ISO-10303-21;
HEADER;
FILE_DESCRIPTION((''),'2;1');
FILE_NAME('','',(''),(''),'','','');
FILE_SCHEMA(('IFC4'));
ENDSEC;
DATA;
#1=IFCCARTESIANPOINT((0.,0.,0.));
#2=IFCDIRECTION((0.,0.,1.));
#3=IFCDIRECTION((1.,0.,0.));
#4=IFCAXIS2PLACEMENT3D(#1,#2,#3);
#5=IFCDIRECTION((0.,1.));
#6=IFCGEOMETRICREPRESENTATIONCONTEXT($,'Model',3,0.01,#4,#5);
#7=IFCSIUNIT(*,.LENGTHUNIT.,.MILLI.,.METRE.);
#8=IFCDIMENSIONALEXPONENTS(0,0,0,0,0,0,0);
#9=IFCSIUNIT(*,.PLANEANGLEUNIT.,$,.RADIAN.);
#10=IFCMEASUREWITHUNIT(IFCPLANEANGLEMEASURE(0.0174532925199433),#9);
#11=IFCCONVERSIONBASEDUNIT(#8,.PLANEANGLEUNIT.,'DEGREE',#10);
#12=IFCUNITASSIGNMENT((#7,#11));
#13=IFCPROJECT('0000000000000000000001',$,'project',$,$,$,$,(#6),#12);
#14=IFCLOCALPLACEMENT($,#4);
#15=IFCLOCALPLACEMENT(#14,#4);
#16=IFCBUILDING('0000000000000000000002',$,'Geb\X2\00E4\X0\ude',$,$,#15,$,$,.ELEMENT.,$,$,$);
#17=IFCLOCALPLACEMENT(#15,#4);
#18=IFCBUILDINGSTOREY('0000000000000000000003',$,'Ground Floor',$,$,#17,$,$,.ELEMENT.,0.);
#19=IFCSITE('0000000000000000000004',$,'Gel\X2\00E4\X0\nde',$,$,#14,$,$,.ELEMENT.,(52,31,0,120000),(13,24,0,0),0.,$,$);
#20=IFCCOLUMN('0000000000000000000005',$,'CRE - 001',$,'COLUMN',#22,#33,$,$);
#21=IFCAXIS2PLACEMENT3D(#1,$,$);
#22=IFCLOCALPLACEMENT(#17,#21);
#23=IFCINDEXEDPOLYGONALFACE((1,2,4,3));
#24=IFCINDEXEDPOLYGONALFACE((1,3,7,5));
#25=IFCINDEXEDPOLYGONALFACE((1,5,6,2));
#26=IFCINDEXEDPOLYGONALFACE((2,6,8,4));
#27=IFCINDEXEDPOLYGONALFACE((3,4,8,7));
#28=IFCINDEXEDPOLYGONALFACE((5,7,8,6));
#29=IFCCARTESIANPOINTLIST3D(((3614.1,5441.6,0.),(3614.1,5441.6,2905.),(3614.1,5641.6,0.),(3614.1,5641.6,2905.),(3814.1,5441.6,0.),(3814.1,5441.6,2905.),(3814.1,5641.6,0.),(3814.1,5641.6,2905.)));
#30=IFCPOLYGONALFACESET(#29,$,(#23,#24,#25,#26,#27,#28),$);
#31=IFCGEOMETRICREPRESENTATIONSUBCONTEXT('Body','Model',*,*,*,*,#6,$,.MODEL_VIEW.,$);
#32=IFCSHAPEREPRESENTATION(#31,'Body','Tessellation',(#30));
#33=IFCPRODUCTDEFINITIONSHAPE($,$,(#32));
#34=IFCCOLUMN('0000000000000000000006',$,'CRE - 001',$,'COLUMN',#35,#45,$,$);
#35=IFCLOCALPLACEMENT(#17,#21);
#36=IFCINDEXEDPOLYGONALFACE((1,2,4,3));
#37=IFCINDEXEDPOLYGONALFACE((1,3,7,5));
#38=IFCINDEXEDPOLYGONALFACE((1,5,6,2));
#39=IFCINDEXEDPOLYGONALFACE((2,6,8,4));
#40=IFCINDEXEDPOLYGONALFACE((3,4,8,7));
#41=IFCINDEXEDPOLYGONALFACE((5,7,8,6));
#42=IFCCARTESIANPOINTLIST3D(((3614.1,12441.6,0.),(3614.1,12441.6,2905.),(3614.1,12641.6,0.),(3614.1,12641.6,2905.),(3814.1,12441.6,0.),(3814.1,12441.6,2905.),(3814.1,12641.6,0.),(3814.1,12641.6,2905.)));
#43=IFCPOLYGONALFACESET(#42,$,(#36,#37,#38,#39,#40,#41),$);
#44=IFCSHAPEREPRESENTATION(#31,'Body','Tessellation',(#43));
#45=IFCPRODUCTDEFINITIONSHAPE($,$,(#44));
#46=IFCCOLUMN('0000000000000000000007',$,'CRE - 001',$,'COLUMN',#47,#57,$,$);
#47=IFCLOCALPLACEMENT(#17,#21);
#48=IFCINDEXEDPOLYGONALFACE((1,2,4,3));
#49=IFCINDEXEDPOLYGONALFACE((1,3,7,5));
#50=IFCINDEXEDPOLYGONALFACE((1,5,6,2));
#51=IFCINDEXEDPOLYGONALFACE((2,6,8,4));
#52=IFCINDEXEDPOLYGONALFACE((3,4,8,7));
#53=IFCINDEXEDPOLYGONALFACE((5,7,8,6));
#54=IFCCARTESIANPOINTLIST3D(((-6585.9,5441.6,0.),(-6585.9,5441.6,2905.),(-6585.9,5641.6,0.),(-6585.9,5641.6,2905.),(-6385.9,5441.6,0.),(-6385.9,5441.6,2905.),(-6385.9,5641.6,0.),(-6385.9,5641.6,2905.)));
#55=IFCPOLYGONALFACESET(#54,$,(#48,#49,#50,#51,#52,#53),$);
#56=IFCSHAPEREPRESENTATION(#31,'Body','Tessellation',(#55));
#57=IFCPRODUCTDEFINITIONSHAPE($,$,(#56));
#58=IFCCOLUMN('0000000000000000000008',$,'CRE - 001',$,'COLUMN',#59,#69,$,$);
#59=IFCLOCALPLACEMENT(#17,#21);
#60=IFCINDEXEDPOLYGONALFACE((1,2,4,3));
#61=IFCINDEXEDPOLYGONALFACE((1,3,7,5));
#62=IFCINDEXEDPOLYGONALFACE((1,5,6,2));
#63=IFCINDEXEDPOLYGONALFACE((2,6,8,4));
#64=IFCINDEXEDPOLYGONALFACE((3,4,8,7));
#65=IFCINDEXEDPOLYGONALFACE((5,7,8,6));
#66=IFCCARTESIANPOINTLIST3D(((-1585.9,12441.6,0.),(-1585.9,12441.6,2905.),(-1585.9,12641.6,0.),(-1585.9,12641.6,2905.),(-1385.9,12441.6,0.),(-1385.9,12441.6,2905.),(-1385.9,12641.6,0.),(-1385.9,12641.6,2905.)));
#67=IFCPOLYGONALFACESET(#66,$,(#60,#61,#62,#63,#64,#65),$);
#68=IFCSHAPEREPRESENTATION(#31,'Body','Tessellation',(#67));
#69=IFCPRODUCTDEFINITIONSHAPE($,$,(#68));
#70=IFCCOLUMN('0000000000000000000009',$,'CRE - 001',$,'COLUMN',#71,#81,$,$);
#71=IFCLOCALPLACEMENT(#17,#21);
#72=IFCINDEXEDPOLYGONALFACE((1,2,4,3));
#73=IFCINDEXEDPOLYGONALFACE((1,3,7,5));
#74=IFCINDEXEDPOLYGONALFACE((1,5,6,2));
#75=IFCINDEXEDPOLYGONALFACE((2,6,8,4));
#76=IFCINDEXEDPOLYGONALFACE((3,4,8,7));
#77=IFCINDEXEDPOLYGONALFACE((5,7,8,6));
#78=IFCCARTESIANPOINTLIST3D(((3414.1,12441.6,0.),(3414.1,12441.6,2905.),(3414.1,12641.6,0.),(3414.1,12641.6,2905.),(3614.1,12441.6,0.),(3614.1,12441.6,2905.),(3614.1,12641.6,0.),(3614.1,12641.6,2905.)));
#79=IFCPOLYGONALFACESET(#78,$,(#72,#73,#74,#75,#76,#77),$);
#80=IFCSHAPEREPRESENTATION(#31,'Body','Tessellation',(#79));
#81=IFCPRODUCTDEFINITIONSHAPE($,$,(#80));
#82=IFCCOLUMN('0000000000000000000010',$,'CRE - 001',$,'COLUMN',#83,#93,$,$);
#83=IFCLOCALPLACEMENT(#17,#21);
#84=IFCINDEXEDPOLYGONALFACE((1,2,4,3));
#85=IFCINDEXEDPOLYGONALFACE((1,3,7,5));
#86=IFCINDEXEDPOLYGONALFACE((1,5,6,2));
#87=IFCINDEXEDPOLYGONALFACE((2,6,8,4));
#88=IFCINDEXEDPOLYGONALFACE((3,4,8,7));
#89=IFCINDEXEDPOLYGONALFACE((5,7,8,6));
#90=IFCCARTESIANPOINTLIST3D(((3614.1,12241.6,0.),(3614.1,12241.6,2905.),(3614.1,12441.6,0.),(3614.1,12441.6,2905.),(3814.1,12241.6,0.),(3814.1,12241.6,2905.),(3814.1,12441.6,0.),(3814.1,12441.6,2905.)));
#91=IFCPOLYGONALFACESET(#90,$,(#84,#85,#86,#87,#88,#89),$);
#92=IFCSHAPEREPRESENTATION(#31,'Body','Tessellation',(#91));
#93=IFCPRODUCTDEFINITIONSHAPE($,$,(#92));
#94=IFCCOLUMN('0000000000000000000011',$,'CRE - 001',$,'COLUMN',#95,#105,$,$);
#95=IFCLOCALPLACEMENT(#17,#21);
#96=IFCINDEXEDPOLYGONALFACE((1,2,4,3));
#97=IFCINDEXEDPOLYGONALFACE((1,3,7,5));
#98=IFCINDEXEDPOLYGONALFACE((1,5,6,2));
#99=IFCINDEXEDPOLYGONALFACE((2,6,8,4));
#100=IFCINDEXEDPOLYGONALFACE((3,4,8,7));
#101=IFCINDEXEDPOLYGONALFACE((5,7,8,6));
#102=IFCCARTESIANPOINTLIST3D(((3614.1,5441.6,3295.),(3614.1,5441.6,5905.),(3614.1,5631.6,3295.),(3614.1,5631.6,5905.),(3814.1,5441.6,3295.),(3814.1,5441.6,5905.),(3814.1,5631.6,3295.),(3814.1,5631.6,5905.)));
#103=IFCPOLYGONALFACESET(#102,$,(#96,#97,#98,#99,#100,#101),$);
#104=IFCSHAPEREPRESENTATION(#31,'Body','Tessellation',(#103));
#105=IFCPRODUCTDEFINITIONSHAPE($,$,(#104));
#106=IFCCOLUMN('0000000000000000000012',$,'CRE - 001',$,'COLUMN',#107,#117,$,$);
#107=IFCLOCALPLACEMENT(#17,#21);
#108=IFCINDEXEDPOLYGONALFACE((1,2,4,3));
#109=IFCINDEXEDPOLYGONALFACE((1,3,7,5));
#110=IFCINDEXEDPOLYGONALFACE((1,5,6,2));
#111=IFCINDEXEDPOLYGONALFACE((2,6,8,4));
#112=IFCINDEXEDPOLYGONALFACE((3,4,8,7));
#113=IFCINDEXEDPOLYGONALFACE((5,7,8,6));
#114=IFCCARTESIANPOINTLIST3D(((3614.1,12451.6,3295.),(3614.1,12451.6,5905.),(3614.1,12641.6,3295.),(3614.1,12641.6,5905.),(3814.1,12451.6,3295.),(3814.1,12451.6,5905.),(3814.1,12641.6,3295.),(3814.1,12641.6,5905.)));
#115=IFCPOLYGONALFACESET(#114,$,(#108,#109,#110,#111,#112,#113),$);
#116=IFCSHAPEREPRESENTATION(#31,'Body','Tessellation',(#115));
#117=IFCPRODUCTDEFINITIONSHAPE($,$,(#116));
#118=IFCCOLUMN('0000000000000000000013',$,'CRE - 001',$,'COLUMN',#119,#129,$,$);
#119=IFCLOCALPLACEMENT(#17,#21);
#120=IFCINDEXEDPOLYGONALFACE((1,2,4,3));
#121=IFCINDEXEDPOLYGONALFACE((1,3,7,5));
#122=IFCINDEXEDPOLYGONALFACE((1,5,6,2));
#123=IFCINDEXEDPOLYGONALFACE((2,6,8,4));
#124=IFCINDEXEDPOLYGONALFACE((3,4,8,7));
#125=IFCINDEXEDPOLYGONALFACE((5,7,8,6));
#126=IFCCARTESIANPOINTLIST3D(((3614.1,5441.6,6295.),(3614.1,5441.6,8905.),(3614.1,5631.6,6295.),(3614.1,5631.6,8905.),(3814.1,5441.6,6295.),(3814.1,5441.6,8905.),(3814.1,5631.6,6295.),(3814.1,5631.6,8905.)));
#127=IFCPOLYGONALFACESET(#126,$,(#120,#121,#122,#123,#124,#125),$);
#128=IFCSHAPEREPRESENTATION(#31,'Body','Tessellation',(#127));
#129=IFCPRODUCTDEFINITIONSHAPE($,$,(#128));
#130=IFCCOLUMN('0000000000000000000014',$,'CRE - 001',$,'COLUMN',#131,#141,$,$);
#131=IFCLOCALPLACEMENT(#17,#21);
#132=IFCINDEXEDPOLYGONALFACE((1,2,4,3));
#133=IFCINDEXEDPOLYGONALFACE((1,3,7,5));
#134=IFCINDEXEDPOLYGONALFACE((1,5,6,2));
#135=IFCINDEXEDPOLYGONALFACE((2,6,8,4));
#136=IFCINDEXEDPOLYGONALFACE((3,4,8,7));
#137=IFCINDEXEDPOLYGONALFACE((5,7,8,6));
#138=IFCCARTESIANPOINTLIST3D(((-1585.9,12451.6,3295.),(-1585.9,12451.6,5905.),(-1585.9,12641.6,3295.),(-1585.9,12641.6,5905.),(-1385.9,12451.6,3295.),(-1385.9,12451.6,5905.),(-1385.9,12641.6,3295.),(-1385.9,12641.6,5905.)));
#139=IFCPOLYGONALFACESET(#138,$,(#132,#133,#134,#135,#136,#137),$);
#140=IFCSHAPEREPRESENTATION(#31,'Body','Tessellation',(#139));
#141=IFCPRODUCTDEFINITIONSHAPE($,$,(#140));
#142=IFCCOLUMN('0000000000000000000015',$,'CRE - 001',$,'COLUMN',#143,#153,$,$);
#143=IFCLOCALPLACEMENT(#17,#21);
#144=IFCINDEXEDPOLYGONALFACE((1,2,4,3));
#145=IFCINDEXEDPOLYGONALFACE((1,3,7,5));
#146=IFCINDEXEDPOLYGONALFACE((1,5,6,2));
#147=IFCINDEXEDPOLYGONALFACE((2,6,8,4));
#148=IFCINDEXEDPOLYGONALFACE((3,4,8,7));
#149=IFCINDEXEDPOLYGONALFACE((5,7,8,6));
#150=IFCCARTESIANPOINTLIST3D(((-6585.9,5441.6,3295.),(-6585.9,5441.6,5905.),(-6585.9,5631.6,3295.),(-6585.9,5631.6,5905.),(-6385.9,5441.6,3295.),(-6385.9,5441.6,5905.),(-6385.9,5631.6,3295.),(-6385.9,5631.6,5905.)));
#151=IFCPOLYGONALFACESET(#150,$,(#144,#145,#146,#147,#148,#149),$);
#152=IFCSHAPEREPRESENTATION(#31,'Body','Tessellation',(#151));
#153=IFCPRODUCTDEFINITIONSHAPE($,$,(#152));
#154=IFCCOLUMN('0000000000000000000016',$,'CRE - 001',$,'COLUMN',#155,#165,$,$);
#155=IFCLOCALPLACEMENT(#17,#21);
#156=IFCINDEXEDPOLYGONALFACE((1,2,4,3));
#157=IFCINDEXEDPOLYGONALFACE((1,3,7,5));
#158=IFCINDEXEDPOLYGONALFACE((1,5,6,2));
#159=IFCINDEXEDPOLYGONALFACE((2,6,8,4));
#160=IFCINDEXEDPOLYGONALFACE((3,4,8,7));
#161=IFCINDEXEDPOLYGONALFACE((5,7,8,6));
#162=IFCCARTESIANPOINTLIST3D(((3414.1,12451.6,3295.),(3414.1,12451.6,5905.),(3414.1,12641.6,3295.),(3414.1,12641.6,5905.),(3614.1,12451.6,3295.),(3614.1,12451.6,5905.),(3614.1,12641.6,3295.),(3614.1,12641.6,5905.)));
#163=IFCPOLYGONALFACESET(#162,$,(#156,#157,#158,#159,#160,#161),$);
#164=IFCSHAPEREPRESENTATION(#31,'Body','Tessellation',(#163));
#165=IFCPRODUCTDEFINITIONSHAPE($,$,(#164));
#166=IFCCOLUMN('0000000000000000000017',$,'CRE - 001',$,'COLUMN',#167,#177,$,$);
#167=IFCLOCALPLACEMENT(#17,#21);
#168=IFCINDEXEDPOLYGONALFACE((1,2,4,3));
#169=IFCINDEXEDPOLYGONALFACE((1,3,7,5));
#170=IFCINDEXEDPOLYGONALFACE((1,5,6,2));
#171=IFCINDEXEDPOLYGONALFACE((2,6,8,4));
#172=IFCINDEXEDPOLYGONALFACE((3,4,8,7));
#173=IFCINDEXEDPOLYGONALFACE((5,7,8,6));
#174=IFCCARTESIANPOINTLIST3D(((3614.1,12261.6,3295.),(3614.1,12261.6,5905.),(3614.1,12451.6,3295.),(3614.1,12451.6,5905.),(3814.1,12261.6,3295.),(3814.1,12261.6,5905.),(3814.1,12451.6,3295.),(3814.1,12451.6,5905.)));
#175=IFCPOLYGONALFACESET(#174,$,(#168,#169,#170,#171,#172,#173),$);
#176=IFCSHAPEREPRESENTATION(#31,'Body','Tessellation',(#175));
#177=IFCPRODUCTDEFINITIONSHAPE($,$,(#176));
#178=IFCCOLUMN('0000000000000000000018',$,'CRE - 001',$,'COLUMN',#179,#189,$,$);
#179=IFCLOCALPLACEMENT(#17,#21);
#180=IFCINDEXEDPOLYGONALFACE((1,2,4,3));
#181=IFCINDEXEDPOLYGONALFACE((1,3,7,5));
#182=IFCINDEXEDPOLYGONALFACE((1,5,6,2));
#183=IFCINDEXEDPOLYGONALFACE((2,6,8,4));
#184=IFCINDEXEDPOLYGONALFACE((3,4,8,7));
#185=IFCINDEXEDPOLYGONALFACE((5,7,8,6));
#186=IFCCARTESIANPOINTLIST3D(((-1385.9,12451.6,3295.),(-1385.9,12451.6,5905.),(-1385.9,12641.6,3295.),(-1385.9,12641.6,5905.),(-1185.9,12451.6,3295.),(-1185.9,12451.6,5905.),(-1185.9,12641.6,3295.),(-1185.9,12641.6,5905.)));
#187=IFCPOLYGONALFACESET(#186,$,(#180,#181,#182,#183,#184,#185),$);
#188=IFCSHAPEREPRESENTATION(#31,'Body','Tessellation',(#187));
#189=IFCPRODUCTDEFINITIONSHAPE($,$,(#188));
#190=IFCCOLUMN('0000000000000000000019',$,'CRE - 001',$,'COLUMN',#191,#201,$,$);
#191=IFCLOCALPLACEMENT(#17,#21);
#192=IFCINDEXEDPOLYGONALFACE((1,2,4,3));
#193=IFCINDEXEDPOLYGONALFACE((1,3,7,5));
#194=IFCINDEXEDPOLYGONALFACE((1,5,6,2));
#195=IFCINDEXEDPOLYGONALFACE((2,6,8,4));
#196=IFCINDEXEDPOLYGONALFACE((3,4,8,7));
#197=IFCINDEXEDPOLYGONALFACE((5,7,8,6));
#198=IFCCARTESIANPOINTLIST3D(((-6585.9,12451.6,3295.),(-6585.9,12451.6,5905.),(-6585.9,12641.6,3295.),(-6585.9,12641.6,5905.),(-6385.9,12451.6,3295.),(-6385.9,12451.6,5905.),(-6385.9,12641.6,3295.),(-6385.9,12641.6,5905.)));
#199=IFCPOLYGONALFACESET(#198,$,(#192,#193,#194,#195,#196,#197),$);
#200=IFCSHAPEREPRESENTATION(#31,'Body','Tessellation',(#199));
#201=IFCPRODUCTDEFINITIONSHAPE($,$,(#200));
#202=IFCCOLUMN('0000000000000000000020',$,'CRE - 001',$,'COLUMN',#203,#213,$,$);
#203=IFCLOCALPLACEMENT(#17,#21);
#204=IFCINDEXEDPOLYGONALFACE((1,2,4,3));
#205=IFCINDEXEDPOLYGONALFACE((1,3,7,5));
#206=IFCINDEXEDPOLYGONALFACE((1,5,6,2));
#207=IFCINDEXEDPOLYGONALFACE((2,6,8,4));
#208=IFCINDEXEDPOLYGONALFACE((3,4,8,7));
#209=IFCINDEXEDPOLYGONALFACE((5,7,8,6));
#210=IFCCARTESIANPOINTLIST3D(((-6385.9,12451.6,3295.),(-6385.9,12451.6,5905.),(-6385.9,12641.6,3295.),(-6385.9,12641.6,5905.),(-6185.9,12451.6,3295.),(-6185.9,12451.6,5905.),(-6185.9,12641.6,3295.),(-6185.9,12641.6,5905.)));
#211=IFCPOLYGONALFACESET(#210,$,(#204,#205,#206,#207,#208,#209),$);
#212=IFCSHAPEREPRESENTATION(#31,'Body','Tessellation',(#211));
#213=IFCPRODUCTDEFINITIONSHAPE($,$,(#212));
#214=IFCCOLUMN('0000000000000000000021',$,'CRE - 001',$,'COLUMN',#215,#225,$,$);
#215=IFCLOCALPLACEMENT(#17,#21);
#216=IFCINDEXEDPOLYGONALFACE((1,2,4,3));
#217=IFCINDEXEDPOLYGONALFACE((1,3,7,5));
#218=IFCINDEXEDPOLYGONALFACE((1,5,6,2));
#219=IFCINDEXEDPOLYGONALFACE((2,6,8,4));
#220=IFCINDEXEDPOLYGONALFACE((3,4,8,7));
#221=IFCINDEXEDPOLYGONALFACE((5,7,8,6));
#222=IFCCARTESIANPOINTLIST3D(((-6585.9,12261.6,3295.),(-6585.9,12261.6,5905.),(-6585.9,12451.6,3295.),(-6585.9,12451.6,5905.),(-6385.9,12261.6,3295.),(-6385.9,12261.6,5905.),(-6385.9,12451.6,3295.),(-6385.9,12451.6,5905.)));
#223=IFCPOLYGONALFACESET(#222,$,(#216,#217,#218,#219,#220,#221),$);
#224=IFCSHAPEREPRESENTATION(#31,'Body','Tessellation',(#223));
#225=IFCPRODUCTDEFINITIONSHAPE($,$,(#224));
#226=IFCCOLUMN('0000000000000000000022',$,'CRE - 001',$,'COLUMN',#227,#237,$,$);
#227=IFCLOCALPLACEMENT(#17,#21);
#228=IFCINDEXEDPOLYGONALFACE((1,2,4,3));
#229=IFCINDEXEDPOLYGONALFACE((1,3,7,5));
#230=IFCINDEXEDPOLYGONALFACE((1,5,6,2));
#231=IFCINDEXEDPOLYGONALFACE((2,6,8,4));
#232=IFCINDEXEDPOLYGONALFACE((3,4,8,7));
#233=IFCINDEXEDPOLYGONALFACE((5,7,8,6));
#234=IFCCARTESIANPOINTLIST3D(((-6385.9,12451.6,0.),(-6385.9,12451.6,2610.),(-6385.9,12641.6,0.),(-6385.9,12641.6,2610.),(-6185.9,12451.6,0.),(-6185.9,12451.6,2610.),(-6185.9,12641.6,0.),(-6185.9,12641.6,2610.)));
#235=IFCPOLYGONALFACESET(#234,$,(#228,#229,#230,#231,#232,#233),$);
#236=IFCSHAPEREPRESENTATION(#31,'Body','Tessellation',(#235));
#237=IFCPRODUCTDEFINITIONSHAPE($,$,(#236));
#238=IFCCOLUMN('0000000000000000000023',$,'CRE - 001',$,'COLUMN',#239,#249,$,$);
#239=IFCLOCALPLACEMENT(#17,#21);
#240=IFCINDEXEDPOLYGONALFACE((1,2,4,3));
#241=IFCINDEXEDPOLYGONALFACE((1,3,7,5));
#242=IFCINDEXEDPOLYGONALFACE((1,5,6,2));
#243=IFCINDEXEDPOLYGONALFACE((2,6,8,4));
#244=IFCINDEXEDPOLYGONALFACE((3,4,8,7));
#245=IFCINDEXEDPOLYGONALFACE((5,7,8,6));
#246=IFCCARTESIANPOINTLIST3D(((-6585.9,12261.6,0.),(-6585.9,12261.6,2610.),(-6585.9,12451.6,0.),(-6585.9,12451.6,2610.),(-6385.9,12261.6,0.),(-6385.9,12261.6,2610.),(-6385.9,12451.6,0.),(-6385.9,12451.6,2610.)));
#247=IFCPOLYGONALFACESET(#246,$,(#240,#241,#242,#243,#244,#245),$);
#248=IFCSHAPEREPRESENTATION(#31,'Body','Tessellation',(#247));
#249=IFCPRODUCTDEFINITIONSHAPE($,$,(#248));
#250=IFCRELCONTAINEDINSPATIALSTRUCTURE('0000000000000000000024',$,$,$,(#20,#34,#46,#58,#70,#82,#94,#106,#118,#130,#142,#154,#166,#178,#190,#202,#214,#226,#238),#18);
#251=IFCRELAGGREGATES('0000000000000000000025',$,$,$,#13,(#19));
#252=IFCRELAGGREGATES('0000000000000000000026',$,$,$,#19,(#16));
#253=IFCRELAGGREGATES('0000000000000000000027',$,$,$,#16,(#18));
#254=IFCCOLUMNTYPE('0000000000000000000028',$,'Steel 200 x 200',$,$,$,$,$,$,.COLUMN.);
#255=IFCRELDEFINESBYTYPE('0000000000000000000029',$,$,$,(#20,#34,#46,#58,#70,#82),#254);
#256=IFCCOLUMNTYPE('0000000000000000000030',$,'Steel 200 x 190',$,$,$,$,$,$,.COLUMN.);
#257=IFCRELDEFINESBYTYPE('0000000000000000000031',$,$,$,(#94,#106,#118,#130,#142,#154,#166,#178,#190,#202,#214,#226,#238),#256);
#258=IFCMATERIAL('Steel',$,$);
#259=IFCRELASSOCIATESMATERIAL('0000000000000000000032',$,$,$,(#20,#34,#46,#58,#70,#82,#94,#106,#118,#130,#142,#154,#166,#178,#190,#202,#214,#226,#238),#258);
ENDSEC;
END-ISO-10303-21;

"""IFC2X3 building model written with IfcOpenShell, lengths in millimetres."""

from ifc_helpers import new_model, entity, si_unit, converted_unit, direction, frame, origin_with_axes, origin_2d_with_axis, place, context, subcontext, project, spatial, rectangle, extrude, material, type_object, element, save


model = new_model("IFC2X3")

# Units and contexts
model_context = context("Model", 3, precision=0.01, world=origin_with_axes(), true_north=direction((0.0, 1.0)))
body_context = subcontext(model_context, "Body", "Model", "MODEL_VIEW")
ifc_project = project(units=[si_unit("LENGTHUNIT", "METRE", prefix="MILLI"), converted_unit("PLANEANGLEUNIT", "DEGREE", entity("IfcPlaneAngleMeasure", 0.0174532925199433), si_unit("PLANEANGLEUNIT", "RADIAN"), dimensions=[0, 0, 0, 0, 0, 0, 0])], contexts=[model_context])

# Site, building, storey
site_placement = place(None, origin_with_axes())
site = spatial("IfcSite", under=ifc_project, at=site_placement, Name="Gelände", CompositionType="ELEMENT", RefLatitude=(52, 31, 0, 120000), RefLongitude=(13, 24, 0, 0), RefElevation=0.0)
building_placement = place(site_placement, origin_with_axes())
building = spatial("IfcBuilding", under=site, at=building_placement, Name="Gebäude", CompositionType="ELEMENT")
storey_placement = place(building_placement, origin_with_axes())
storey = spatial("IfcBuildingStorey", under=building, at=storey_placement, Name="Ground Floor", CompositionType="ELEMENT", Elevation=0.0)

# Columns
ifc_material_1 = material(Name="Steel")
column_type_1 = type_object("IfcColumnType", Name="Steel 200 x 200", PredefinedType="COLUMN")
for number, where, z_axis, x_axis, name in (
    (1, (3714.1, 5541.6, 0.0), (0.0, 0.0, 1.0), (1.0, 0.0, 0.0), "CRE - 001"),
    (2, (3714.1, 12541.6, 0.0), (0.0, 0.0, 1.0), (1.0, 0.0, 0.0), "CRE - 001"),
    (3, (-6485.9, 5541.6, 0.0), (0.0, 0.0, 1.0), (1.0, 0.0, 0.0), "CRE - 001"),
    (4, (-1485.9, 12541.6, 0.0), (0.0, 0.0, 1.0), (1.0, 0.0, 0.0), "CRE - 001"),
    (5, (3514.1, 12541.6, 0.0), (0.0, 0.0, 1.0), (1.0, 0.0, 0.0), "CRE - 001"),
    (6, (3714.1, 12341.6, 0.0), (0.0, 0.0, 1.0), (1.0, 0.0, 0.0), "CRE - 001"),
):
    element("IfcColumn", number, at=place(storey_placement, frame(where, z_axis=z_axis, x_axis=x_axis)), inside=storey, type_object=column_type_1, material=ifc_material_1, Name=name, ObjectType="COLUMN", context=body_context, shape_type="SweptSolid", body=[
        extrude(rectangle(XDim=200.0, YDim=200.0, at=origin_2d_with_axis()), origin_with_axes(), (0.0, 0.0, 1.0), 2905.0),
    ])
column_type_2 = type_object("IfcColumnType", Name="Steel 200 x 190", PredefinedType="COLUMN")
for number, where, z_axis, x_axis, name in (
    (7, (3714.1, 5536.6, 3295.0), (0.0, 0.0, 1.0), (1.0, 0.0, 0.0), "CRE - 001"),
    (8, (3714.1, 12546.6, 3295.0), (0.0, 0.0, 1.0), (1.0, 0.0, 0.0), "CRE - 001"),
    (9, (3714.1, 5536.6, 6295.0), (0.0, 0.0, 1.0), (1.0, 0.0, 0.0), "CRE - 001"),
    (10, (-1485.9, 12546.6, 3295.0), (0.0, 0.0, 1.0), (1.0, 0.0, 0.0), "CRE - 001"),
    (11, (-6485.9, 5536.6, 3295.0), (0.0, 0.0, 1.0), (1.0, 0.0, 0.0), "CRE - 001"),
    (12, (3514.1, 12546.6, 3295.0), (0.0, 0.0, 1.0), (1.0, 0.0, 0.0), "CRE - 001"),
    (13, (3714.1, 12356.6, 3295.0), (0.0, 0.0, 1.0), (1.0, 0.0, 0.0), "CRE - 001"),
    (14, (-1285.9, 12546.6, 3295.0), (0.0, 0.0, 1.0), (1.0, 0.0, 0.0), "CRE - 001"),
    (15, (-6485.9, 12546.6, 3295.0), (0.0, 0.0, 1.0), (1.0, 0.0, 0.0), "CRE - 001"),
    (16, (-6285.9, 12546.6, 3295.0), (0.0, 0.0, 1.0), (1.0, 0.0, 0.0), "CRE - 001"),
    (17, (-6485.9, 12356.6, 3295.0), (0.0, 0.0, 1.0), (1.0, 0.0, 0.0), "CRE - 001"),
    (18, (-6285.9, 12546.6, 0.0), (0.0, 0.0, 1.0), (1.0, 0.0, 0.0), "CRE - 001"),
    (19, (-6485.9, 12356.6, 0.0), (0.0, 0.0, 1.0), (1.0, 0.0, 0.0), "CRE - 001"),
):
    element("IfcColumn", number, at=place(storey_placement, frame(where, z_axis=z_axis, x_axis=x_axis)), inside=storey, type_object=column_type_2, material=ifc_material_1, Name=name, ObjectType="COLUMN", context=body_context, shape_type="SweptSolid", body=[
        extrude(rectangle(XDim=200.0, YDim=190.0, at=origin_2d_with_axis()), origin_with_axes(), (0.0, 0.0, 1.0), 2610.0),
    ])

save(model, "model.ifc")
